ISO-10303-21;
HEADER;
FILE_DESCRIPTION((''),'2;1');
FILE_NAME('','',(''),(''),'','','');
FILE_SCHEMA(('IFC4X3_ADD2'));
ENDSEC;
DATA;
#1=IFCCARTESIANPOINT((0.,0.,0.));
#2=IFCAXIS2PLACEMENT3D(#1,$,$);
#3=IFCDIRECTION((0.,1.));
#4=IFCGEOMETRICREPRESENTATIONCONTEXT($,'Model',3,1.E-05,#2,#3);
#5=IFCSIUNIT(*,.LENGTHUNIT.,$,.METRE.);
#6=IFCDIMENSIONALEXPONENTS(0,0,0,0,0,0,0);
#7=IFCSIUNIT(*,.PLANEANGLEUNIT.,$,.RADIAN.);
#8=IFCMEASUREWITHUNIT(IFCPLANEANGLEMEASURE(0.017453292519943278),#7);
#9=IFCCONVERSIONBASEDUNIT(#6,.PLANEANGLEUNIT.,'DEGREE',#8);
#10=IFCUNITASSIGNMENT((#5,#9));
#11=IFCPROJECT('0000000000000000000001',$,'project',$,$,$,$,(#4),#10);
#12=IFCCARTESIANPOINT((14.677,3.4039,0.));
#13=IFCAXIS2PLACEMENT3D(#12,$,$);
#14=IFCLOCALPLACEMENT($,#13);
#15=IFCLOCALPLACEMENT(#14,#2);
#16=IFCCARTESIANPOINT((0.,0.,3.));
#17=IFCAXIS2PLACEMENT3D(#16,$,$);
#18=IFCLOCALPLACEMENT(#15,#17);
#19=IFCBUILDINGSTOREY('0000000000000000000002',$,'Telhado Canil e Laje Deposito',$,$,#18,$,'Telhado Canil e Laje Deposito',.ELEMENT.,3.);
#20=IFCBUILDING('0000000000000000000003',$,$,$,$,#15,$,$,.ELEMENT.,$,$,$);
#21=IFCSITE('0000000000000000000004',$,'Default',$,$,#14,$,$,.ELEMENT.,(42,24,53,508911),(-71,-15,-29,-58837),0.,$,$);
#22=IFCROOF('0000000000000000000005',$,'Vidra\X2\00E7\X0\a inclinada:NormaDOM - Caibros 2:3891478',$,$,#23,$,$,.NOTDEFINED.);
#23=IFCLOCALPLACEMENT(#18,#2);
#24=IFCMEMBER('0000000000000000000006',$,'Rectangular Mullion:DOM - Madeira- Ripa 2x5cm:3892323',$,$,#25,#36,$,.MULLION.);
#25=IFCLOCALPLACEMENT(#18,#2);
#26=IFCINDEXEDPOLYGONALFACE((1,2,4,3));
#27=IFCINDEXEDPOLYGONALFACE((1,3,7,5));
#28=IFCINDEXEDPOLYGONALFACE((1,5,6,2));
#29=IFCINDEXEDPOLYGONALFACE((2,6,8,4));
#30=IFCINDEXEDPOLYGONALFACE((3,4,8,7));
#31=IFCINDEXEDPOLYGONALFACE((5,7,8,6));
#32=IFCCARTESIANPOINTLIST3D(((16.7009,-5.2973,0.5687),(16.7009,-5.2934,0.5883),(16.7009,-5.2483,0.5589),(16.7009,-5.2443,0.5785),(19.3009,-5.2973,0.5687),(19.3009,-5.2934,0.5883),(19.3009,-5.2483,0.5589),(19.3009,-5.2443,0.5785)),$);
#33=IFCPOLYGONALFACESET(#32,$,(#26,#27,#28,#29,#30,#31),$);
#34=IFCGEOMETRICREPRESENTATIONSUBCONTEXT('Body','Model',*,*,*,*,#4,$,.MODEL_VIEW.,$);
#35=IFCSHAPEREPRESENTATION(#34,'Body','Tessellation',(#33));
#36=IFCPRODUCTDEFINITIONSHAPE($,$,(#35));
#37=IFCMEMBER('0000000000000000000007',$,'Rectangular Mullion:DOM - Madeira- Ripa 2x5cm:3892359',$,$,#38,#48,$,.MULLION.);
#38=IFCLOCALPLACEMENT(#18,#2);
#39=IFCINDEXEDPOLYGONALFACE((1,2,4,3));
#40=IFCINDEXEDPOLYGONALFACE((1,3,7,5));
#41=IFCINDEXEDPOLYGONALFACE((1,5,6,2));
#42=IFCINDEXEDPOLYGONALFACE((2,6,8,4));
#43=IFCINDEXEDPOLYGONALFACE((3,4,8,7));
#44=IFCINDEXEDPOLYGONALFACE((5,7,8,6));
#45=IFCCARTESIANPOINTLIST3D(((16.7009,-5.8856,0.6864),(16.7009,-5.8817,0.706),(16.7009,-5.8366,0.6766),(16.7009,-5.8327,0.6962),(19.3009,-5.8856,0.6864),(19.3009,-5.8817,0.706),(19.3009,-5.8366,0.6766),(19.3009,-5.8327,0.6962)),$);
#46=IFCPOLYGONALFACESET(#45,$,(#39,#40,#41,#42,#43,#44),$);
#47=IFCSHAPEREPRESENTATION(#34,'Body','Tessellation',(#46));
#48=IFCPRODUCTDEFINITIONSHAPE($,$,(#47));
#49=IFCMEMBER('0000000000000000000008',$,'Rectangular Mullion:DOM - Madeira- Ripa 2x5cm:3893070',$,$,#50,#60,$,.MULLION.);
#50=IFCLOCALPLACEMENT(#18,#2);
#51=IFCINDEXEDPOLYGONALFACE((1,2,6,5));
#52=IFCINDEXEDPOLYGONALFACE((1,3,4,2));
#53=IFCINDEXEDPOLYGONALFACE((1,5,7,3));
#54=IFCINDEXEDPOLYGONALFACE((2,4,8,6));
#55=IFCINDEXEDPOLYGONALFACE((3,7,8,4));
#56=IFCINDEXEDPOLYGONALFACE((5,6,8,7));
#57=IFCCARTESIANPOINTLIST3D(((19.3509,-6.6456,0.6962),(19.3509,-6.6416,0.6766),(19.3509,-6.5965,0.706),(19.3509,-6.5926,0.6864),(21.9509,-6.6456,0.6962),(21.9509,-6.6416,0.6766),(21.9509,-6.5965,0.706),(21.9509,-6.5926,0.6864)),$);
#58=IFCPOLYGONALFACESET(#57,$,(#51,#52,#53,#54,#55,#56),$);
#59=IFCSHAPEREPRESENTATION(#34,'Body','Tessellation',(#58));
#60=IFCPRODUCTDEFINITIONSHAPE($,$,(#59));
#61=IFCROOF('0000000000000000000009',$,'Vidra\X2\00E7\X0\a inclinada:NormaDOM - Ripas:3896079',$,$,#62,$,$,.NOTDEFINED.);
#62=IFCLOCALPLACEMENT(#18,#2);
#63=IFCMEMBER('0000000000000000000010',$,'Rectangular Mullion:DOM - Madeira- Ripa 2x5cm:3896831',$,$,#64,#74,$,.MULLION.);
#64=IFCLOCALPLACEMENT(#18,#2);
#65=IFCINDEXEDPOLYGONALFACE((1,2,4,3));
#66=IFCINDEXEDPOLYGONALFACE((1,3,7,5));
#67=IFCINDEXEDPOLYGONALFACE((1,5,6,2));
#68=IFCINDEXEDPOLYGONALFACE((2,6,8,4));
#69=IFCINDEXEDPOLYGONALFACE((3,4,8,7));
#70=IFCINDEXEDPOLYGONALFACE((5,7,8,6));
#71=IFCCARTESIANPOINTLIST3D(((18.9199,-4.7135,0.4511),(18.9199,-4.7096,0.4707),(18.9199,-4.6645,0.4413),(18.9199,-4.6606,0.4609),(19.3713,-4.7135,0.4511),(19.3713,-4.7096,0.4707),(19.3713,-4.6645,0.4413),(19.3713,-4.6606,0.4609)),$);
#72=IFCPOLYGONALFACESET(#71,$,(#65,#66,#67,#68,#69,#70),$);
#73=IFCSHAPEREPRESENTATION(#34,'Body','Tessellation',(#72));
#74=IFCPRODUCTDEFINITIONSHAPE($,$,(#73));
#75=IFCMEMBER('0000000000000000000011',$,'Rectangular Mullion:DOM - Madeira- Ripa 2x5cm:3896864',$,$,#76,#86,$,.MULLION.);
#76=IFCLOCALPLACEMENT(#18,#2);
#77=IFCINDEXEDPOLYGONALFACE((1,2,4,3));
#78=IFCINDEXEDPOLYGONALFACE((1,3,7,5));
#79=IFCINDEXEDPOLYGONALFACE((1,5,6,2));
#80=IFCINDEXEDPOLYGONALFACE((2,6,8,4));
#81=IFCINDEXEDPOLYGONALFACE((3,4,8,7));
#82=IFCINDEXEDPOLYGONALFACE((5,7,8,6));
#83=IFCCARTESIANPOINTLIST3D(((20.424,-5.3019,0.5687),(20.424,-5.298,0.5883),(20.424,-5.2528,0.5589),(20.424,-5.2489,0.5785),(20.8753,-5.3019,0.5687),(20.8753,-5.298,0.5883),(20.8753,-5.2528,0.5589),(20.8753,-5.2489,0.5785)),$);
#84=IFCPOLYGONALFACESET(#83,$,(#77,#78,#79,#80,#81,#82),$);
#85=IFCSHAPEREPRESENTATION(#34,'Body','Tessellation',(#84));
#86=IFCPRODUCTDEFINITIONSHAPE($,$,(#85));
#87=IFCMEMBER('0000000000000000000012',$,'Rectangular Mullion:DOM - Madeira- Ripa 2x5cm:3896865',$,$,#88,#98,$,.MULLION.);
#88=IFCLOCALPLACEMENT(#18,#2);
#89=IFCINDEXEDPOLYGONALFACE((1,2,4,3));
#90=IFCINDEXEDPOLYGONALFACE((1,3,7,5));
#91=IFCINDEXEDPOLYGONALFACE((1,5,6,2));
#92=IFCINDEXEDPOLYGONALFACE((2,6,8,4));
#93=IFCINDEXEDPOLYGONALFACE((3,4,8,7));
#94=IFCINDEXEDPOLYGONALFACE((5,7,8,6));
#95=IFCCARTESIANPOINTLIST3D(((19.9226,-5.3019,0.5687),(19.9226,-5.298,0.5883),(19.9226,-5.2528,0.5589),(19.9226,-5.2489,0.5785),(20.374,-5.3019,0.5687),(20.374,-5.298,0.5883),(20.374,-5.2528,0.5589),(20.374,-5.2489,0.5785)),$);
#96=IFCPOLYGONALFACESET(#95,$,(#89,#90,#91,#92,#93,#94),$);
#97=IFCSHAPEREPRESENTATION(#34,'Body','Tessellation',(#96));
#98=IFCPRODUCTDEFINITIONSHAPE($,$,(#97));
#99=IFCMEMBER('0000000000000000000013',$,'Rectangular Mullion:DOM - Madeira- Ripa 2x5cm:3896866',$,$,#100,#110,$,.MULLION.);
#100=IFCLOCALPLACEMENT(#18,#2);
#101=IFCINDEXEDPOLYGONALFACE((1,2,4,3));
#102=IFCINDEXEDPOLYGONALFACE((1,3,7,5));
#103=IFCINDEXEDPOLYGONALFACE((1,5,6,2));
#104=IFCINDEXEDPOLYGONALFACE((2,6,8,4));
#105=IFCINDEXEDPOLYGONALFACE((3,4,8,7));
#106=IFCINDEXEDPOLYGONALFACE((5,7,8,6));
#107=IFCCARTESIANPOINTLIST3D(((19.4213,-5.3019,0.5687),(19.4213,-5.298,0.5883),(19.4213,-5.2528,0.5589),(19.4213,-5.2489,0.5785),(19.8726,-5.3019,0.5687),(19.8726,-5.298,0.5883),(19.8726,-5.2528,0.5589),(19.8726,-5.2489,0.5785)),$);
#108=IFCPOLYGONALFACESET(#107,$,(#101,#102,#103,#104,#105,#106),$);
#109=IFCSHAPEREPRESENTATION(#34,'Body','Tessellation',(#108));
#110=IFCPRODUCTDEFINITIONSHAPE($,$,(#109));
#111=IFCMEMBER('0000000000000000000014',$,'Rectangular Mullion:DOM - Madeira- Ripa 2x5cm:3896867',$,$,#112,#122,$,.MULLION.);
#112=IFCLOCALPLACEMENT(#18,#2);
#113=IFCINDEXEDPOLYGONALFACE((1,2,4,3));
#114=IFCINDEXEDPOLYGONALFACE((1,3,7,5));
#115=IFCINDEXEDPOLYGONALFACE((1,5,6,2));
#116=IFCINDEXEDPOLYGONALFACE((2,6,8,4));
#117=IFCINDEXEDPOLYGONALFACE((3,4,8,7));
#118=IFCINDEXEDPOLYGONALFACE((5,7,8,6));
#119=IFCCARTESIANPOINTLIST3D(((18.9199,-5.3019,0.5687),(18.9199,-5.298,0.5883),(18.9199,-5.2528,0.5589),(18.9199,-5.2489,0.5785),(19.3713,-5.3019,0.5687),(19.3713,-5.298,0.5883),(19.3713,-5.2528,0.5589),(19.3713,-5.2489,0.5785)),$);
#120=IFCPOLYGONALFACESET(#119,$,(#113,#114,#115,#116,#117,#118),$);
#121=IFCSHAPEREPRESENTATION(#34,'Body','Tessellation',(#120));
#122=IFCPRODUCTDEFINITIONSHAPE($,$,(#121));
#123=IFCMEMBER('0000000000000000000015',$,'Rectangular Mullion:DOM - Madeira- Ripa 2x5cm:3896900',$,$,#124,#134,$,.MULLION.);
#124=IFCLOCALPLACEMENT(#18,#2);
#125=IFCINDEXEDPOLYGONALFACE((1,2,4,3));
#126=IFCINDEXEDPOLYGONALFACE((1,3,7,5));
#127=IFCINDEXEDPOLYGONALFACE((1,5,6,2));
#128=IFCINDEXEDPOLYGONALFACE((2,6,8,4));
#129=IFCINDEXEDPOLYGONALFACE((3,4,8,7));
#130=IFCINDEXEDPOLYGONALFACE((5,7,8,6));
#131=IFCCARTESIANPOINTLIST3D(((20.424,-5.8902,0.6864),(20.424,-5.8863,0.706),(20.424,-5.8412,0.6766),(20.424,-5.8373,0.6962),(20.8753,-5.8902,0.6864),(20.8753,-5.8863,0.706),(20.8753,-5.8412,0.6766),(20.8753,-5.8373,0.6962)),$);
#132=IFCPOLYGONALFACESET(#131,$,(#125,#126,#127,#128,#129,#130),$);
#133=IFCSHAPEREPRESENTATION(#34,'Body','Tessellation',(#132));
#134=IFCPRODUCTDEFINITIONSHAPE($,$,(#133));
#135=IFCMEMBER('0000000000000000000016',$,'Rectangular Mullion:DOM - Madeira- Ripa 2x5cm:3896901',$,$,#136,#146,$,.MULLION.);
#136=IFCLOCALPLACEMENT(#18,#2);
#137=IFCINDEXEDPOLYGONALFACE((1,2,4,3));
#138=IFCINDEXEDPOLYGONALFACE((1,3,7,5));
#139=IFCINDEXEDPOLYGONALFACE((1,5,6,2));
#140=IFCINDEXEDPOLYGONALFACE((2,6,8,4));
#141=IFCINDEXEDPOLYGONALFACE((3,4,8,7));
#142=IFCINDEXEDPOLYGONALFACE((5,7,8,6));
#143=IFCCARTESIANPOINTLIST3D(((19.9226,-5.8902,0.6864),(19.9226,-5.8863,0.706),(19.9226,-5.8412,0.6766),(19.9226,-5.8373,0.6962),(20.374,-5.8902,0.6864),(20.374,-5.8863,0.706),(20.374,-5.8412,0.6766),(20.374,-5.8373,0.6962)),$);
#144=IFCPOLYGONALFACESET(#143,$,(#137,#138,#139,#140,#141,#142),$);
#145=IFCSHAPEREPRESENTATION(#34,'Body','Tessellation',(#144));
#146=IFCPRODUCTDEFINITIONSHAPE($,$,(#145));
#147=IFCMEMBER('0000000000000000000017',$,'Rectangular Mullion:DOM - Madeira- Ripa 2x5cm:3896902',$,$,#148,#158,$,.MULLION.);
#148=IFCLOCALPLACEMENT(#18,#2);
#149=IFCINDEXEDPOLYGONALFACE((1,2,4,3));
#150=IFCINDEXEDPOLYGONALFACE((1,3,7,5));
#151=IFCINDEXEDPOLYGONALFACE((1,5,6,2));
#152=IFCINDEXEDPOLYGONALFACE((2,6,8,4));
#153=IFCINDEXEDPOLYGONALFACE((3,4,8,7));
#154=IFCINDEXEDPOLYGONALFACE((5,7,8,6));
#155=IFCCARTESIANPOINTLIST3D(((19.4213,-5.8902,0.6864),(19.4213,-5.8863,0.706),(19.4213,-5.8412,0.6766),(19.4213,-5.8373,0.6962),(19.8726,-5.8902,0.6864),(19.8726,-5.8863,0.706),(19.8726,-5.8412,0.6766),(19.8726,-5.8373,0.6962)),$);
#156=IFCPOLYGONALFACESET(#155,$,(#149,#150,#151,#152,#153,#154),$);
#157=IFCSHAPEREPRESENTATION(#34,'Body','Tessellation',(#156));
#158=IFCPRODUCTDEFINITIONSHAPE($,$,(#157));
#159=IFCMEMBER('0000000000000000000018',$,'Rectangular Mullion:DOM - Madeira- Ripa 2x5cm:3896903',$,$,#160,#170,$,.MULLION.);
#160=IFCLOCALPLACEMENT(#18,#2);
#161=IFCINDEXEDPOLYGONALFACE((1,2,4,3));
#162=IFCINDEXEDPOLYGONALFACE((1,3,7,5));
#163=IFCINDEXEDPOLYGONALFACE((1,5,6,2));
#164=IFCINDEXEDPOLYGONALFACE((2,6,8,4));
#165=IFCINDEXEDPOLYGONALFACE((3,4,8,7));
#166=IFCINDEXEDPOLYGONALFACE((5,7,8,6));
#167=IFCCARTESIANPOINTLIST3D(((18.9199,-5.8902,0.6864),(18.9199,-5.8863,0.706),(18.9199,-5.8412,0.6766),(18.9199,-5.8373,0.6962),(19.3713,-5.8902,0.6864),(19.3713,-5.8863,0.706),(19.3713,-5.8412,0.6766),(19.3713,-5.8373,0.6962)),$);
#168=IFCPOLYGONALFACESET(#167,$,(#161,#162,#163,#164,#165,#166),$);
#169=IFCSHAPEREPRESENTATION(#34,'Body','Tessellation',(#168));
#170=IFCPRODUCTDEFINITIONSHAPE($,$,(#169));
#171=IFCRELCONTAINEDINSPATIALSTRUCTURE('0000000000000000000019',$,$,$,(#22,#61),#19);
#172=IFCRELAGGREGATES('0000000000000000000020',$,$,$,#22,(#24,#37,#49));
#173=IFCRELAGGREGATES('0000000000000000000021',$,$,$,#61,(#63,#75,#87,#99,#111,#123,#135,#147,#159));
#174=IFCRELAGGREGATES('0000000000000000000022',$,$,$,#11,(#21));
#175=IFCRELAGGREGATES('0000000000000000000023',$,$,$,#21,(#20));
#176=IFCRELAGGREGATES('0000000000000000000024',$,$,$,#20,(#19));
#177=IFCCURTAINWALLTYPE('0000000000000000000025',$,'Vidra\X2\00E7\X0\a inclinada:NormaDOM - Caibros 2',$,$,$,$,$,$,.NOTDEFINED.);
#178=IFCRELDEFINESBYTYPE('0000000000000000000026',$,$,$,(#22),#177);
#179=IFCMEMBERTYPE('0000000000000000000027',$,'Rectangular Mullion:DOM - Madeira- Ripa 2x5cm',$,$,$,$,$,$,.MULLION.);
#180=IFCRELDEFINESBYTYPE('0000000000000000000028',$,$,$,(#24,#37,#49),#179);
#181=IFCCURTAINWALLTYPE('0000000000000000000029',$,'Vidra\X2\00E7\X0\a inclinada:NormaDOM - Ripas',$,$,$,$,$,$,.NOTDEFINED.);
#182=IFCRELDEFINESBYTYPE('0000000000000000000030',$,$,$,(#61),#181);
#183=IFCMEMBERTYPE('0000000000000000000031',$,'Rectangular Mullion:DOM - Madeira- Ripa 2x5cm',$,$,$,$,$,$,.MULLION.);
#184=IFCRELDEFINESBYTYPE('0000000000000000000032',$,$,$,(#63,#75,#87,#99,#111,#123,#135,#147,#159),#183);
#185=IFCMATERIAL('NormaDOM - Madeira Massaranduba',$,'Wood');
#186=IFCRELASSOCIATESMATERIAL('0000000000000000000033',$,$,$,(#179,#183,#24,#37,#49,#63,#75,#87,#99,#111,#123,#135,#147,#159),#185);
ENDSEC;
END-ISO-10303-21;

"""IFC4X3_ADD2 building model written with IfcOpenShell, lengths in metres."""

from ifc_helpers import new_model, entity, si_unit, converted_unit, direction, frame, origin, origin_2d_with_axis, place, context, subcontext, project, spatial, rectangle, extrude, source, transform, mapped, material, material_profile, profile_set, profile_usage, type_object, type_shapes, element, aggregate, save


model = new_model("IFC4X3_ADD2")

# Units and contexts
model_context = context("Model", 3, precision=1e-05, world=origin(), true_north=direction((0.0, 1.0)))
body_context = subcontext(model_context, "Body", "Model", "MODEL_VIEW")
ifc_project = project(units=[si_unit("LENGTHUNIT", "METRE"), converted_unit("PLANEANGLEUNIT", "DEGREE", entity("IfcPlaneAngleMeasure", 0.017453292519943278), si_unit("PLANEANGLEUNIT", "RADIAN"), dimensions=[0, 0, 0, 0, 0, 0, 0])], contexts=[model_context])

# Site, building, storey
site_placement = place(None, frame((14.677, 3.4039, 0.0)))
site = spatial("IfcSite", under=ifc_project, at=site_placement, Name="Default", CompositionType="ELEMENT", RefLatitude=(42, 24, 53, 508911), RefLongitude=(-71, -15, -29, -58837), RefElevation=0.0)
building_placement = place(site_placement, origin())
building = spatial("IfcBuilding", under=site, at=building_placement, CompositionType="ELEMENT")
storey_placement = place(building_placement, frame((0.0, 0.0, 3.0)))
storey = spatial("IfcBuildingStorey", under=building, at=storey_placement, Name="Telhado Canil e Laje Deposito", LongName="Telhado Canil e Laje Deposito", CompositionType="ELEMENT", Elevation=3.0)

# Roofs, members
curtain_wall_type_1 = type_object("IfcCurtainWallType", Name="Vidraça inclinada:NormaDOM - Caibros 2", PredefinedType="NOTDEFINED")
roof_1_placement = place(storey_placement, frame((0.0, 0.0, -3.0)))
roof_1 = element("IfcRoof", 1, at=roof_1_placement, inside=storey, type_object=curtain_wall_type_1, Name="Vidraça inclinada:NormaDOM - Caibros 2:3891478", PredefinedType="NOTDEFINED")
ifc_material = material(Name="NormaDOM - Madeira Massaranduba", Category="Wood")
ifc_material_profile_1 = material_profile(ifc_material, rectangle(XDim=0.05, YDim=0.02, at=origin_2d_with_axis()), Name="DOM - Madeira- Ripa 2x5cm")
ifc_profile_set_1 = profile_set([ifc_material_profile_1], Name="DOM - Madeira- Ripa 2x5cm")
ifc_profile_usage_1 = profile_usage(ifc_profile_set_1)
member_type_1 = type_object("IfcMemberType", Name="Rectangular Mullion:DOM - Madeira- Ripa 2x5cm", PredefinedType="MULLION", material=ifc_profile_set_1)
shared_shape_1 = source(origin(), body_context, "Body", "SweptSolid", [
    extrude(rectangle(XDim=0.05, YDim=0.02, at=origin_2d_with_axis()), frame((0.025, 0.01, -2.6), z_axis=(0.0, 0.0, 1.0), x_axis=(-1.0, 0.0, 0.0)), (0.0, 0.0, 1.0), 2.6),
])
type_shapes(member_type_1, [shared_shape_1])
member_1_placement = place(roof_1_placement, frame((19.3009, -5.2443, 3.5785), z_axis=(1.0, 0.0, 0.0), x_axis=(0.0, -0.980581, 0.196116)))
member_1 = element("IfcMember", 2, at=member_1_placement, type_object=member_type_1, material=ifc_profile_usage_1, Name="Rectangular Mullion:DOM - Madeira- Ripa 2x5cm:3892323", PredefinedType="MULLION", context=body_context, shape_type="MappedRepresentation", body=[
    mapped(shared_shape_1, transform((0.0, 0.0, 0.0), scale=1.0)),
])
member_2_placement = place(roof_1_placement, frame((19.3009, -5.8327, 3.6962), z_axis=(1.0, 0.0, 0.0), x_axis=(0.0, -0.980581, 0.196116)))
member_2 = element("IfcMember", 3, at=member_2_placement, type_object=member_type_1, material=ifc_profile_usage_1, Name="Rectangular Mullion:DOM - Madeira- Ripa 2x5cm:3892359", PredefinedType="MULLION", context=body_context, shape_type="MappedRepresentation", body=[
    mapped(shared_shape_1, transform((0.0, 0.0, 0.0), scale=1.0)),
])
member_3_placement = place(roof_1_placement, frame((19.3509, -6.6456, 3.6962), z_axis=(-1.0, 0.0, 0.0), x_axis=(0.0, 0.980581, 0.196116)))
member_3 = element("IfcMember", 4, at=member_3_placement, type_object=member_type_1, material=ifc_profile_usage_1, Name="Rectangular Mullion:DOM - Madeira- Ripa 2x5cm:3893070", PredefinedType="MULLION", context=body_context, shape_type="MappedRepresentation", body=[
    mapped(shared_shape_1, transform((0.0, 0.0, 0.0), scale=1.0)),
])
curtain_wall_type_2 = type_object("IfcCurtainWallType", Name="Vidraça inclinada:NormaDOM - Ripas", PredefinedType="NOTDEFINED")
roof_2_placement = place(storey_placement, frame((0.0, 0.0, -3.0)))
roof_2 = element("IfcRoof", 5, at=roof_2_placement, inside=storey, type_object=curtain_wall_type_2, Name="Vidraça inclinada:NormaDOM - Ripas:3896079", PredefinedType="NOTDEFINED")

# Members
aggregate(roof_1, [member_1, member_2, member_3])
member_type_2 = type_object("IfcMemberType", Name="Rectangular Mullion:DOM - Madeira- Ripa 2x5cm", PredefinedType="MULLION", material=ifc_profile_set_1)
shared_shape_2 = source(origin(), body_context, "Body", "SweptSolid", [
    extrude(rectangle(XDim=0.05, YDim=0.02, at=origin_2d_with_axis()), frame((0.025, 0.01, -0.4514), z_axis=(0.0, 0.0, 1.0), x_axis=(-1.0, 0.0, 0.0)), (0.0, 0.0, 1.0), 0.4514),
])
type_shapes(member_type_2, [shared_shape_2])
member_4_placement = place(roof_2_placement, frame((19.3713, -4.6606, 3.4609), z_axis=(1.0, 0.0, 0.0), x_axis=(0.0, -0.980581, 0.196116)))
member_4 = element("IfcMember", 6, at=member_4_placement, type_object=member_type_2, material=ifc_profile_usage_1, Name="Rectangular Mullion:DOM - Madeira- Ripa 2x5cm:3896831", PredefinedType="MULLION", context=body_context, shape_type="MappedRepresentation", body=[
    mapped(shared_shape_2, transform((0.0, 0.0, 0.0), scale=1.0)),
])
member_5_placement = place(roof_2_placement, frame((20.8753, -5.2489, 3.5785), z_axis=(1.0, 0.0, 0.0), x_axis=(0.0, -0.980581, 0.196116)))
member_5 = element("IfcMember", 7, at=member_5_placement, type_object=member_type_2, material=ifc_profile_usage_1, Name="Rectangular Mullion:DOM - Madeira- Ripa 2x5cm:3896864", PredefinedType="MULLION", context=body_context, shape_type="MappedRepresentation", body=[
    mapped(shared_shape_2, transform((0.0, 0.0, 0.0), scale=1.0)),
])
member_6_placement = place(roof_2_placement, frame((20.374, -5.2489, 3.5785), z_axis=(1.0, 0.0, 0.0), x_axis=(0.0, -0.980581, 0.196116)))
member_6 = element("IfcMember", 8, at=member_6_placement, type_object=member_type_2, material=ifc_profile_usage_1, Name="Rectangular Mullion:DOM - Madeira- Ripa 2x5cm:3896865", PredefinedType="MULLION", context=body_context, shape_type="MappedRepresentation", body=[
    mapped(shared_shape_2, transform((0.0, 0.0, 0.0), scale=1.0)),
])
member_7_placement = place(roof_2_placement, frame((19.8726, -5.2489, 3.5785), z_axis=(1.0, 0.0, 0.0), x_axis=(0.0, -0.980581, 0.196116)))
member_7 = element("IfcMember", 9, at=member_7_placement, type_object=member_type_2, material=ifc_profile_usage_1, Name="Rectangular Mullion:DOM - Madeira- Ripa 2x5cm:3896866", PredefinedType="MULLION", context=body_context, shape_type="MappedRepresentation", body=[
    mapped(shared_shape_2, transform((0.0, 0.0, 0.0), scale=1.0)),
])
member_8_placement = place(roof_2_placement, frame((19.3713, -5.2489, 3.5785), z_axis=(1.0, 0.0, 0.0), x_axis=(0.0, -0.980581, 0.196116)))
member_8 = element("IfcMember", 10, at=member_8_placement, type_object=member_type_2, material=ifc_profile_usage_1, Name="Rectangular Mullion:DOM - Madeira- Ripa 2x5cm:3896867", PredefinedType="MULLION", context=body_context, shape_type="MappedRepresentation", body=[
    mapped(shared_shape_2, transform((0.0, 0.0, 0.0), scale=1.0)),
])
member_9_placement = place(roof_2_placement, frame((20.8753, -5.8373, 3.6962), z_axis=(1.0, 0.0, 0.0), x_axis=(0.0, -0.980581, 0.196116)))
member_9 = element("IfcMember", 11, at=member_9_placement, type_object=member_type_2, material=ifc_profile_usage_1, Name="Rectangular Mullion:DOM - Madeira- Ripa 2x5cm:3896900", PredefinedType="MULLION", context=body_context, shape_type="MappedRepresentation", body=[
    mapped(shared_shape_2, transform((0.0, 0.0, 0.0), scale=1.0)),
])
member_10_placement = place(roof_2_placement, frame((20.374, -5.8373, 3.6962), z_axis=(1.0, 0.0, 0.0), x_axis=(0.0, -0.980581, 0.196116)))
member_10 = element("IfcMember", 12, at=member_10_placement, type_object=member_type_2, material=ifc_profile_usage_1, Name="Rectangular Mullion:DOM - Madeira- Ripa 2x5cm:3896901", PredefinedType="MULLION", context=body_context, shape_type="MappedRepresentation", body=[
    mapped(shared_shape_2, transform((0.0, 0.0, 0.0), scale=1.0)),
])
member_11_placement = place(roof_2_placement, frame((19.8726, -5.8373, 3.6962), z_axis=(1.0, 0.0, 0.0), x_axis=(0.0, -0.980581, 0.196116)))
member_11 = element("IfcMember", 13, at=member_11_placement, type_object=member_type_2, material=ifc_profile_usage_1, Name="Rectangular Mullion:DOM - Madeira- Ripa 2x5cm:3896902", PredefinedType="MULLION", context=body_context, shape_type="MappedRepresentation", body=[
    mapped(shared_shape_2, transform((0.0, 0.0, 0.0), scale=1.0)),
])
member_12_placement = place(roof_2_placement, frame((19.3713, -5.8373, 3.6962), z_axis=(1.0, 0.0, 0.0), x_axis=(0.0, -0.980581, 0.196116)))
member_12 = element("IfcMember", 14, at=member_12_placement, type_object=member_type_2, material=ifc_profile_usage_1, Name="Rectangular Mullion:DOM - Madeira- Ripa 2x5cm:3896903", PredefinedType="MULLION", context=body_context, shape_type="MappedRepresentation", body=[
    mapped(shared_shape_2, transform((0.0, 0.0, 0.0), scale=1.0)),
])
aggregate(roof_2, [member_4, member_5, member_6, member_7, member_8, member_9, member_10, member_11, member_12])

save(model, "model.ifc")
